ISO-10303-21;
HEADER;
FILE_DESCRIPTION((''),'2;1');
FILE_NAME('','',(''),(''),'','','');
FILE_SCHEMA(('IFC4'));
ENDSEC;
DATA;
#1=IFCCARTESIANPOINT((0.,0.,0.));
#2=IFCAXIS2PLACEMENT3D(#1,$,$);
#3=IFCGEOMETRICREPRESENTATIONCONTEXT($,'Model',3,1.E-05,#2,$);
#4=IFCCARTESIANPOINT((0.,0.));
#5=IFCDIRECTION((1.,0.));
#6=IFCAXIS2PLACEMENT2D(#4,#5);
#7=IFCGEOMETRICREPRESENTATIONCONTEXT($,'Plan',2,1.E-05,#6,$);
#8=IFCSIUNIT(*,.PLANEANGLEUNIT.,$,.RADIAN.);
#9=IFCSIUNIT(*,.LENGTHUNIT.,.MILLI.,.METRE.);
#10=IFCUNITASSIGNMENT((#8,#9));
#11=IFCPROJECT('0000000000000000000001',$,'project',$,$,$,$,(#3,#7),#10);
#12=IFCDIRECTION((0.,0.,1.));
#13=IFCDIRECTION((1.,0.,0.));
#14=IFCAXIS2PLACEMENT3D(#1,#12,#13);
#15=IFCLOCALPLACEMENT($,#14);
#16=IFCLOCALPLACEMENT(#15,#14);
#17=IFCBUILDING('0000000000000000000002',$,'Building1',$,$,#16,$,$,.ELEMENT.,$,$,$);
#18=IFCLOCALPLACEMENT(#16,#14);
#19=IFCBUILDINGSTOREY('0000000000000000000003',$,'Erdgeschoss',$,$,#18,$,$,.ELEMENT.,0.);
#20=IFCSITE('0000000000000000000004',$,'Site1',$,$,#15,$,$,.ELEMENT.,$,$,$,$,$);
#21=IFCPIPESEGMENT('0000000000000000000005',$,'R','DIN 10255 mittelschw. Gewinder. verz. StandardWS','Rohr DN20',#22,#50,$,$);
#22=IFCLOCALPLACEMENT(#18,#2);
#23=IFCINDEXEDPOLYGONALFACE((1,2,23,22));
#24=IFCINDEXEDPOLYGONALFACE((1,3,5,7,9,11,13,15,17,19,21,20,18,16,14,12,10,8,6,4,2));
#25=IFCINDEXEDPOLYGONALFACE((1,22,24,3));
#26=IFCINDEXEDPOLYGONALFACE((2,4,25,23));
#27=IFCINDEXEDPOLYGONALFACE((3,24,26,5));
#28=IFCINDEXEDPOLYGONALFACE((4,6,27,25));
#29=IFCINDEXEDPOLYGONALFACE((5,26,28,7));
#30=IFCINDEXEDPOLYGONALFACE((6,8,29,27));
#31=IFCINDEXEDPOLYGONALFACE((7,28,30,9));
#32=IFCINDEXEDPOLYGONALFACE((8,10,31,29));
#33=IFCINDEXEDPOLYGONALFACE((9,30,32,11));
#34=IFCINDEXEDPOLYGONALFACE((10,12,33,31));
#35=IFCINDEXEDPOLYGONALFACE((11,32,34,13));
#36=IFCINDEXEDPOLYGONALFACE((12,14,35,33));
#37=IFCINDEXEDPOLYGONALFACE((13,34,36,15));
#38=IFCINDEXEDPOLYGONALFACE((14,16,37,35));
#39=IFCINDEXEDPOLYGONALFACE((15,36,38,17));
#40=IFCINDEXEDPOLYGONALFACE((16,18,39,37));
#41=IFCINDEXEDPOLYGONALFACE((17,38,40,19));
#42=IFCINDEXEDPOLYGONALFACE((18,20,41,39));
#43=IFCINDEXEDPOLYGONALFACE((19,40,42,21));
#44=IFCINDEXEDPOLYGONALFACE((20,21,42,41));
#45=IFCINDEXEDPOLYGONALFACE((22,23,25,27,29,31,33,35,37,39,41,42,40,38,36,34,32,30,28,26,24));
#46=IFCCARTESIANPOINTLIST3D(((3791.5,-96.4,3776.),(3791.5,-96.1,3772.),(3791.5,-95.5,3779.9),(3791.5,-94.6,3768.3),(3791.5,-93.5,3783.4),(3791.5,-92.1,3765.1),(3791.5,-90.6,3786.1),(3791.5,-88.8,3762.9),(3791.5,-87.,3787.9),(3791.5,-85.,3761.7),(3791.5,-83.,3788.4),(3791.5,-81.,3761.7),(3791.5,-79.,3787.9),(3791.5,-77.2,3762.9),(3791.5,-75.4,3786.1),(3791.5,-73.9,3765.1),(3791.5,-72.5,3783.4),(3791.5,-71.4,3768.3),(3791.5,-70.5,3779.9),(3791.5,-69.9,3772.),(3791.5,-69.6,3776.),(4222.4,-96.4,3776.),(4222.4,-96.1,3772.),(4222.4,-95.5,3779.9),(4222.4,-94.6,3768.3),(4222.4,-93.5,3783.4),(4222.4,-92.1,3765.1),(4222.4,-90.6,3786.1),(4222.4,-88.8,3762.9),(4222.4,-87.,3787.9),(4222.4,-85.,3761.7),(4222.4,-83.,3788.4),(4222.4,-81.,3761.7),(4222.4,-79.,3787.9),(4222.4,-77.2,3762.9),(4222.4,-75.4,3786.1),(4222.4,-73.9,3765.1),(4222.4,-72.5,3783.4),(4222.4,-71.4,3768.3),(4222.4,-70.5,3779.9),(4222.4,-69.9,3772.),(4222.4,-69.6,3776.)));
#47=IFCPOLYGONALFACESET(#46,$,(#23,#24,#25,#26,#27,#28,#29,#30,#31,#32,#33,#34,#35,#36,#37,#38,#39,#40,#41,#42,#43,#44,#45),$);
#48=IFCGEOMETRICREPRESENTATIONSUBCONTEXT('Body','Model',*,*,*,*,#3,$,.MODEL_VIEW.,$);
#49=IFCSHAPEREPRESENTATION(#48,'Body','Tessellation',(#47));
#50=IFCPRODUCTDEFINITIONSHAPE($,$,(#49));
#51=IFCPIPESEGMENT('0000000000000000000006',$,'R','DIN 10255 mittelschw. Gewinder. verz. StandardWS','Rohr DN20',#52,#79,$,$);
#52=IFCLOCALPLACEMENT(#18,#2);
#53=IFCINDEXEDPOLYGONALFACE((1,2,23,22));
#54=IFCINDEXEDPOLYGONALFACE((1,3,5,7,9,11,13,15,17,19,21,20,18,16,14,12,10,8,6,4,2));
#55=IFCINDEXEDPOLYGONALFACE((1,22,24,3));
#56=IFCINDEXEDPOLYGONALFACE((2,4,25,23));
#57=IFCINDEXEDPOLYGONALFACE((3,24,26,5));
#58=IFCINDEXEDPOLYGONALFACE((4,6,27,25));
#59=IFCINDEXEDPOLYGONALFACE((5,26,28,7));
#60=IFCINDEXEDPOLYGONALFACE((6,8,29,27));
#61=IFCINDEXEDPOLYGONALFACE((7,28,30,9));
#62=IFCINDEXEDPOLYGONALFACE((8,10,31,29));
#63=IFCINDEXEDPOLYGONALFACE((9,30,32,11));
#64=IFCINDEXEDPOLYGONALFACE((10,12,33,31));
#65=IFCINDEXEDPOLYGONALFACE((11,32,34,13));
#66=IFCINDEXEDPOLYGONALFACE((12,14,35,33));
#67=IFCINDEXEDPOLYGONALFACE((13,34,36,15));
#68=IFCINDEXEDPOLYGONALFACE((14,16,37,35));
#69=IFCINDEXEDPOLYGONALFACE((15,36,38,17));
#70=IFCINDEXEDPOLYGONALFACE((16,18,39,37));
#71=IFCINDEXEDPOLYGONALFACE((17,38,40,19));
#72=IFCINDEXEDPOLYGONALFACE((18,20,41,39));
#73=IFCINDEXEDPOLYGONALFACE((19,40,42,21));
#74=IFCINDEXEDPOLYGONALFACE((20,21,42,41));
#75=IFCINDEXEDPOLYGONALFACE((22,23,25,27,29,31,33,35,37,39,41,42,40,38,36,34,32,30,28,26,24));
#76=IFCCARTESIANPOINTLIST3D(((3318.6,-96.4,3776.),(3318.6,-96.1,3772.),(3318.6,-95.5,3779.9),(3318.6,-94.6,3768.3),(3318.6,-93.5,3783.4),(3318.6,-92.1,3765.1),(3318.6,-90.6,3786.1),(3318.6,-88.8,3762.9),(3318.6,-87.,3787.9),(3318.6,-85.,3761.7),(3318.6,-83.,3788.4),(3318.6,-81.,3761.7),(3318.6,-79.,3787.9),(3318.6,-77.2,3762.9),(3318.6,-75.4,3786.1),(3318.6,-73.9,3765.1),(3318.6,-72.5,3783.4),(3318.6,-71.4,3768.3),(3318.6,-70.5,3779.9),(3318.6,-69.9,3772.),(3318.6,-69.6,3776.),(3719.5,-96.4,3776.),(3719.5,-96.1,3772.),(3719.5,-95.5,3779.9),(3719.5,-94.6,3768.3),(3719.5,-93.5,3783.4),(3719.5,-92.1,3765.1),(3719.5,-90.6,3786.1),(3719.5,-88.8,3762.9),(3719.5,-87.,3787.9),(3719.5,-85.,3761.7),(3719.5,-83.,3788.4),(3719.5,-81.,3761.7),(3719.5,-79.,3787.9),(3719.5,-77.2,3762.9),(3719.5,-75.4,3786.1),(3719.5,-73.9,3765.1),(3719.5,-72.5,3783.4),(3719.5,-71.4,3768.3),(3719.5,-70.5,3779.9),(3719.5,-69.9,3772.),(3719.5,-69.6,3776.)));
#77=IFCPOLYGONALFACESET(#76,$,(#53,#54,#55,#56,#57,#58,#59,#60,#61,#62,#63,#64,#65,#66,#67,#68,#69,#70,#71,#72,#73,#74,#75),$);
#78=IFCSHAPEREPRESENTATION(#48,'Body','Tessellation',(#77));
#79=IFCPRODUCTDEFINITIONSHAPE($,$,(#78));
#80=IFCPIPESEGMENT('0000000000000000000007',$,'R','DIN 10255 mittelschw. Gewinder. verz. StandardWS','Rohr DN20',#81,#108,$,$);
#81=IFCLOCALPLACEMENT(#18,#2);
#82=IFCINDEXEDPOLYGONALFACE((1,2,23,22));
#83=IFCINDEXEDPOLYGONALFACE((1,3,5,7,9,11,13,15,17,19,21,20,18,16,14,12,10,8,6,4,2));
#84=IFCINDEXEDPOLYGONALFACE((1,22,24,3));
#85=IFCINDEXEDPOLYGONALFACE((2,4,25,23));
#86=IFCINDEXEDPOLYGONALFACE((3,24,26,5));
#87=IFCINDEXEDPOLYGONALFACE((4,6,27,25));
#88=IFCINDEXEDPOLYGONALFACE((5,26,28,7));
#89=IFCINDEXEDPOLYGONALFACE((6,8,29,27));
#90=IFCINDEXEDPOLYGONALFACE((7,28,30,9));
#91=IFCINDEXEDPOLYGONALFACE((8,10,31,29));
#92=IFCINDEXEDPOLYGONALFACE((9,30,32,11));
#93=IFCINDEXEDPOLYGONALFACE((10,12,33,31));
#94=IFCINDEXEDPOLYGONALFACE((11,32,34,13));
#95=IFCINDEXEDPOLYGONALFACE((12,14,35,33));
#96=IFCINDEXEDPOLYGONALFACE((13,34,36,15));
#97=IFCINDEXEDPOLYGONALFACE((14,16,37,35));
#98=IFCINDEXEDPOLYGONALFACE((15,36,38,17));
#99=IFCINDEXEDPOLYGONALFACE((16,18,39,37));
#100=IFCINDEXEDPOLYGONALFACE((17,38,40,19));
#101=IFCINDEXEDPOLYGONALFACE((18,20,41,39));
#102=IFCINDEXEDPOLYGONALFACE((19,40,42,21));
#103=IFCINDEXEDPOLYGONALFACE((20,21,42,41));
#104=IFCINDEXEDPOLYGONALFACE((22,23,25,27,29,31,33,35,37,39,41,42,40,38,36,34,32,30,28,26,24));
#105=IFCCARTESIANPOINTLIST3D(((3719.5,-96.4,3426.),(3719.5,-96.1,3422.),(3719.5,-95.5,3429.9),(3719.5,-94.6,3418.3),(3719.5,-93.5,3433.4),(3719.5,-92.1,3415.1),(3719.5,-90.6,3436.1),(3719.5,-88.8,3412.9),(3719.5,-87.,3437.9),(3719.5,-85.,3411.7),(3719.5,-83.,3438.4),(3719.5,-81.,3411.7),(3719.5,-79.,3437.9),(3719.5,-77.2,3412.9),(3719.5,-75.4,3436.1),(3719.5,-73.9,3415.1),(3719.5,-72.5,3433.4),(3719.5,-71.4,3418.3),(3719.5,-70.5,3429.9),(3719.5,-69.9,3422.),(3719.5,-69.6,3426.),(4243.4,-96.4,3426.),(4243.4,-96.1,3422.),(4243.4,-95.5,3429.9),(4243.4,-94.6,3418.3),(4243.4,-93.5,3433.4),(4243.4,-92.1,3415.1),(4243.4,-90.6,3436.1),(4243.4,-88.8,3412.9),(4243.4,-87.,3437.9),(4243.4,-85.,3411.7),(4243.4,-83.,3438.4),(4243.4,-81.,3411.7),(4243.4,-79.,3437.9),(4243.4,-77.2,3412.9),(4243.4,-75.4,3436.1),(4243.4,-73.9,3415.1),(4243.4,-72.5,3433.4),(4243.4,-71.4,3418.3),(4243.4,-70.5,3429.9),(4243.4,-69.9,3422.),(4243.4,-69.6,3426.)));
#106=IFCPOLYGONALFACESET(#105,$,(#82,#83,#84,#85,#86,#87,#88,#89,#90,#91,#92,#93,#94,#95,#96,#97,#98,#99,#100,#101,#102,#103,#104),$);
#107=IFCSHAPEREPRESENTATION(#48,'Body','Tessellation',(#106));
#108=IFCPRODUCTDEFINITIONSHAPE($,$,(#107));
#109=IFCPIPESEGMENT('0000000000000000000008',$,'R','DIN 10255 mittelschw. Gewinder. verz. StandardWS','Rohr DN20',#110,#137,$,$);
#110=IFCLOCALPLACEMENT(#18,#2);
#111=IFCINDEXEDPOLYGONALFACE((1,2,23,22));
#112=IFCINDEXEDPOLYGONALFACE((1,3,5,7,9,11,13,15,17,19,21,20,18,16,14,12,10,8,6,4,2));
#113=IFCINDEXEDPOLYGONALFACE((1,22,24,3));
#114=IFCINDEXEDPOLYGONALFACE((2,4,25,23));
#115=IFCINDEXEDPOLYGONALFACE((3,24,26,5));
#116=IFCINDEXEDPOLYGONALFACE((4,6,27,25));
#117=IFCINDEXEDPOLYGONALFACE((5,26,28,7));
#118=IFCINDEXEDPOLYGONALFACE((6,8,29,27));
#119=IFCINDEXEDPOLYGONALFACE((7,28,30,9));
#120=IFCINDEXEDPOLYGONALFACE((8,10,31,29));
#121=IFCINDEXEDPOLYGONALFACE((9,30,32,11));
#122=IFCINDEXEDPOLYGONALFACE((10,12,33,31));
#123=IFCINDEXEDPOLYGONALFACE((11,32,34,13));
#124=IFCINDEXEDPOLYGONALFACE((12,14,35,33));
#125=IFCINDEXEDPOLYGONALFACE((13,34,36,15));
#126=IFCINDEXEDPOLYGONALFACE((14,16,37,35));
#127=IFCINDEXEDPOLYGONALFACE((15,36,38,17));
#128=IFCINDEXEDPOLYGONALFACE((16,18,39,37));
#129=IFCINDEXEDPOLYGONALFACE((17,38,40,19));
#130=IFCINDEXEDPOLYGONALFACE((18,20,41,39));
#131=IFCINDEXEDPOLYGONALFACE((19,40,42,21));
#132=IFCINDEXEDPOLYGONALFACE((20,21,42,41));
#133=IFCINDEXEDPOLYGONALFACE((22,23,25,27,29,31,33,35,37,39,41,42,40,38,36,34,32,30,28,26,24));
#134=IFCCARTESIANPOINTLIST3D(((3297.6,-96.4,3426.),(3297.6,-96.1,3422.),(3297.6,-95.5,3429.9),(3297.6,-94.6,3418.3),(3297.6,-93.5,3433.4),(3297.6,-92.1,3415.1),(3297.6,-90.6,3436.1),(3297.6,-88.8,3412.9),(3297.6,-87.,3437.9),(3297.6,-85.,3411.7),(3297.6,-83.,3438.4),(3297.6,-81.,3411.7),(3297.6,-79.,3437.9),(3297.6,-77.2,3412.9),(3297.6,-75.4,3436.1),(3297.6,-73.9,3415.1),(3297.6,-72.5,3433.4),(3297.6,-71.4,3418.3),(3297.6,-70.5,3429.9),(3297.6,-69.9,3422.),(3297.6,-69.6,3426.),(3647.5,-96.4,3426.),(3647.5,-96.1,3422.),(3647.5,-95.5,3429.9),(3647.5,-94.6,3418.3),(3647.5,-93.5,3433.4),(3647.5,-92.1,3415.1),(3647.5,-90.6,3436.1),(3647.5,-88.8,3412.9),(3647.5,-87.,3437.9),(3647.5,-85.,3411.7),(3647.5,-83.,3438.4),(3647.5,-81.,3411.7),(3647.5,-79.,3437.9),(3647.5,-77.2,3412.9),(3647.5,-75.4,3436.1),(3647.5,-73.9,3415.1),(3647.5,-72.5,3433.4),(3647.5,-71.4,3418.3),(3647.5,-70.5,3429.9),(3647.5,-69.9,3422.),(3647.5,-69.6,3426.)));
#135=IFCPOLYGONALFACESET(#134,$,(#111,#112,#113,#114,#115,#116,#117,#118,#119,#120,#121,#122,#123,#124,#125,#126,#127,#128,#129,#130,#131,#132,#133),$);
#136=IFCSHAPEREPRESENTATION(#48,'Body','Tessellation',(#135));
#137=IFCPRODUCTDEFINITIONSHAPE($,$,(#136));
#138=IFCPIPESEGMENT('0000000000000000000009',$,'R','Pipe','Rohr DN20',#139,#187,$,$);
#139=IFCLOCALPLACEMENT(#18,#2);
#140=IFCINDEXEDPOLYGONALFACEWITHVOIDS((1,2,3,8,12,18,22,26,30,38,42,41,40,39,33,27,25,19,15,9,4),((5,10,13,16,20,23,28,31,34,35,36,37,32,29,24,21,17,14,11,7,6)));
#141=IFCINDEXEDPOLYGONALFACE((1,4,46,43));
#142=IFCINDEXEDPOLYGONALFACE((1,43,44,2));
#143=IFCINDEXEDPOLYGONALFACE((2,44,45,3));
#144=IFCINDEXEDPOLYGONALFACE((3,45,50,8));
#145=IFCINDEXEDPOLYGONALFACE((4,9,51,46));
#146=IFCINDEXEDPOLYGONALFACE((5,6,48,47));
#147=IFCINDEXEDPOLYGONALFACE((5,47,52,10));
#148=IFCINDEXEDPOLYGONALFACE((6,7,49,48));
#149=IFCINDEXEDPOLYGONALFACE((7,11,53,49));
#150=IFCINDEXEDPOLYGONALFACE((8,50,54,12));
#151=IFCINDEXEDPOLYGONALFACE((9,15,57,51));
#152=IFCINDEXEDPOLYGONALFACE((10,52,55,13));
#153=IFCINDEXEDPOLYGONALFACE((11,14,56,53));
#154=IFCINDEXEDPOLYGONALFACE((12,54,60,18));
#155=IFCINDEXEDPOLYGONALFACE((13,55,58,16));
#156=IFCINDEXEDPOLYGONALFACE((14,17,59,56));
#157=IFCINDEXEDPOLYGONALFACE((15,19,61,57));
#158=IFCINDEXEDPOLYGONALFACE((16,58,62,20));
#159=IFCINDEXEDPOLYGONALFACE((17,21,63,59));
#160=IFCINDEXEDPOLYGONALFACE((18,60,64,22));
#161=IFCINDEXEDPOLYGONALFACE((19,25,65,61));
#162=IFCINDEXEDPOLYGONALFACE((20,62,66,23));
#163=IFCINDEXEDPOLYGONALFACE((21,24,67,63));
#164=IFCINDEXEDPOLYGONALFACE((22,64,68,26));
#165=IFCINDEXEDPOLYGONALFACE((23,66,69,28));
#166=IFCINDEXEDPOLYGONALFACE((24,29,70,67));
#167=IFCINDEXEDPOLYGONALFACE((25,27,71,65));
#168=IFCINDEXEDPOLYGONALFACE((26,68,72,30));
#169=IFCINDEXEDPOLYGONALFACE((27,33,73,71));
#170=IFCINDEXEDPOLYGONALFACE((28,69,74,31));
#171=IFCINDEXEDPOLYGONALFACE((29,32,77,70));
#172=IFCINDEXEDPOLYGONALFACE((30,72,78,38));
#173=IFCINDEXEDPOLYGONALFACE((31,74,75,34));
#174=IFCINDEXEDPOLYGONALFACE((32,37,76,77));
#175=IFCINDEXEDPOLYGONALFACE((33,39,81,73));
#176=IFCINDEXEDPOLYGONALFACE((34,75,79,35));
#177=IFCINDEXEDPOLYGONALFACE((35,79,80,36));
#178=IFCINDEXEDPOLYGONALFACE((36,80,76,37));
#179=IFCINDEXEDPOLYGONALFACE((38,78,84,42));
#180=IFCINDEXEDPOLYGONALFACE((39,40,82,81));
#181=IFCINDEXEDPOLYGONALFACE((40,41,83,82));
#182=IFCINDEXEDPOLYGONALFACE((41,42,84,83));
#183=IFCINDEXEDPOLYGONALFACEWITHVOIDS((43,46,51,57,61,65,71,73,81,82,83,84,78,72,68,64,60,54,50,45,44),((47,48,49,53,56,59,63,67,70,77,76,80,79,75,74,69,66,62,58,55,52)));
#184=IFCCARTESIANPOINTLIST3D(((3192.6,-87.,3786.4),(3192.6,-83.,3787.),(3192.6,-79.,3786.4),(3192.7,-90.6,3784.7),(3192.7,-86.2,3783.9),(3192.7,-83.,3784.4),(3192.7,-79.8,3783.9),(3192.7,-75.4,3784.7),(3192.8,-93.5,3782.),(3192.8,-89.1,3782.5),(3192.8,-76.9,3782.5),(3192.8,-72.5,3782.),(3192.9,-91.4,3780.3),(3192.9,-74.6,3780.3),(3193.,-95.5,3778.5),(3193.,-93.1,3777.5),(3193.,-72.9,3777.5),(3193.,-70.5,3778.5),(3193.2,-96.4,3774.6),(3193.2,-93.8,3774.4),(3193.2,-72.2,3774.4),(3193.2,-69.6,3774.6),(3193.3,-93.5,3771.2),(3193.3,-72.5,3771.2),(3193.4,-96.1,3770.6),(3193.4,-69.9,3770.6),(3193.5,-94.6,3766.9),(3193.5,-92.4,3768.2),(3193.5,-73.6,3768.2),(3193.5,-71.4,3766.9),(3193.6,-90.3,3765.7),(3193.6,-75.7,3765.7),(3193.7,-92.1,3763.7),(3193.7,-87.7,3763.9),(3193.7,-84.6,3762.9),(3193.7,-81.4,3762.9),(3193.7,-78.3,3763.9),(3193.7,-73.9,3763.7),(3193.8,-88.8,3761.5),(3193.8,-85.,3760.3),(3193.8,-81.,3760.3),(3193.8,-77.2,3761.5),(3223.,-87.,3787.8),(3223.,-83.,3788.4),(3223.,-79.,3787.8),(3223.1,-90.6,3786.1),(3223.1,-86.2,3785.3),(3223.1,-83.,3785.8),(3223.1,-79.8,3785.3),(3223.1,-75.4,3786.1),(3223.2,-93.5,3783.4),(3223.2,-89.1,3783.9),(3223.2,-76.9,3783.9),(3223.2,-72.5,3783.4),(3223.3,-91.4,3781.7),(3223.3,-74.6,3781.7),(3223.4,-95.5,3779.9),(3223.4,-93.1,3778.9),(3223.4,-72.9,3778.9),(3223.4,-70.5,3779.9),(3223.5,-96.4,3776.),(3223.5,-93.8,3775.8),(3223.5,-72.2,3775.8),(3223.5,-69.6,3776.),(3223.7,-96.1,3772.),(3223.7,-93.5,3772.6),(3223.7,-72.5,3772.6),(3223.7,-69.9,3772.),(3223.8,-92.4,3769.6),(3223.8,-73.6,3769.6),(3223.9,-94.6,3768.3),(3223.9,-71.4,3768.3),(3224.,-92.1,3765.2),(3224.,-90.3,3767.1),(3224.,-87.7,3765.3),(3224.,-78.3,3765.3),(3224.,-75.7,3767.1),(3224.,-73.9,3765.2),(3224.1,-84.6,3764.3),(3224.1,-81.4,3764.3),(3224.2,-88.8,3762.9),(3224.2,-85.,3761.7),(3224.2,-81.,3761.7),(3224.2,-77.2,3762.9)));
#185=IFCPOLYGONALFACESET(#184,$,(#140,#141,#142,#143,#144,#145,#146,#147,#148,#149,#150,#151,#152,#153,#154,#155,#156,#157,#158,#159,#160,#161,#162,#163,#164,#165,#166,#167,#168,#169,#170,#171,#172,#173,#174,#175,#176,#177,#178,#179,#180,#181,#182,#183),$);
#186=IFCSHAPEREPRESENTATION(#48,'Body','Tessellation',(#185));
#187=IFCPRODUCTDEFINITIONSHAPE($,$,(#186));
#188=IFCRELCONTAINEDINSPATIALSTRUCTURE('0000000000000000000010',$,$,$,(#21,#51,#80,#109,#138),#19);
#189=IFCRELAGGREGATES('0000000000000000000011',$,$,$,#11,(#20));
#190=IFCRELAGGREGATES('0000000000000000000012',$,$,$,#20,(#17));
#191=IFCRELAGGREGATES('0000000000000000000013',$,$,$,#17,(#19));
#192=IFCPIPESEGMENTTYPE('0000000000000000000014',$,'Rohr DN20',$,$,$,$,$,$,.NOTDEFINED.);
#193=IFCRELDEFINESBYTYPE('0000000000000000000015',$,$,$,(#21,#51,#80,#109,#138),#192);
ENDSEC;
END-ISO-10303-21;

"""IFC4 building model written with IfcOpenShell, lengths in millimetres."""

from ifc_helpers import new_model, si_unit, frame, origin, origin_with_axes, origin_2d_with_axis, place, context, subcontext, project, spatial, circle, hollow_circle, extrude, type_object, element, save


model = new_model("IFC4")

# Units and contexts
model_context = context("Model", 3, precision=1e-05, world=origin())
plan_context = context("Plan", 2, precision=1e-05, world=origin_2d_with_axis())
body_context = subcontext(model_context, "Body", "Model", "MODEL_VIEW")
ifc_project = project(units=[si_unit("PLANEANGLEUNIT", "RADIAN"), si_unit("LENGTHUNIT", "METRE", prefix="MILLI")], contexts=[model_context, plan_context])

# Site, building, storey
site_placement = place(None, origin_with_axes())
site = spatial("IfcSite", under=ifc_project, at=site_placement, Name="Site1", CompositionType="ELEMENT")
building_placement = place(site_placement, origin_with_axes())
building = spatial("IfcBuilding", under=site, at=building_placement, Name="Building1", CompositionType="ELEMENT")
storey_placement = place(building_placement, origin_with_axes())
storey = spatial("IfcBuildingStorey", under=building, at=storey_placement, Name="Erdgeschoss", CompositionType="ELEMENT", Elevation=0.0)

# Pipe segments
pipe_segment_type_1 = type_object("IfcPipeSegmentType", Name="Rohr DN20", PredefinedType="NOTDEFINED")
pipe_segment_1_placement = place(storey_placement, frame((4006.9, -83.2, 3775.0), z_axis=(0.0, 0.0, 1.0), x_axis=(1.0, 0.0, 0.0)))
element("IfcPipeSegment", 1, at=pipe_segment_1_placement, inside=storey, type_object=pipe_segment_type_1, Name="R", Description="DIN 10255 mittelschw. Gewinder. verz. StandardWS", ObjectType="Rohr DN20", context=body_context, shape_type="SolidModel", body=[
    extrude(circle(Radius=13.4, at=origin_2d_with_axis()), frame((215.5, 0.2, 0.0), z_axis=(-1.0, 0.0, 0.0), x_axis=(0.0, 0.0, 1.0)), (0.0, 0.0, 1.0), 430.9),
])
pipe_segment_2_placement = place(storey_placement, frame((3519.0, -83.2, 3775.0), z_axis=(0.0, 0.0, 1.0), x_axis=(1.0, 0.0, 0.0)))
element("IfcPipeSegment", 2, at=pipe_segment_2_placement, inside=storey, type_object=pipe_segment_type_1, Name="R", Description="DIN 10255 mittelschw. Gewinder. verz. StandardWS", ObjectType="Rohr DN20", context=body_context, shape_type="SolidModel", body=[
    extrude(circle(Radius=13.4, at=origin_2d_with_axis()), frame((200.5, 0.2, 0.0), z_axis=(-1.0, 0.0, 0.0), x_axis=(0.0, 0.0, 1.0)), (0.0, 0.0, 1.0), 400.9),
])
pipe_segment_3_placement = place(storey_placement, frame((3981.4, -83.2, 3425.0), z_axis=(0.0, 0.0, 1.0), x_axis=(1.0, 0.0, 0.0)))
element("IfcPipeSegment", 3, at=pipe_segment_3_placement, inside=storey, type_object=pipe_segment_type_1, Name="R", Description="DIN 10255 mittelschw. Gewinder. verz. StandardWS", ObjectType="Rohr DN20", context=body_context, shape_type="SolidModel", body=[
    extrude(circle(Radius=13.4, at=origin_2d_with_axis()), frame((261.9, 0.2, 0.0), z_axis=(-1.0, 0.0, 0.0), x_axis=(0.0, 0.0, 1.0)), (0.0, 0.0, 1.0), 523.9),
])
pipe_segment_4_placement = place(storey_placement, frame((3472.5, -83.2, 3425.0), z_axis=(0.0, 0.0, 1.0), x_axis=(1.0, 0.0, 0.0)))
element("IfcPipeSegment", 4, at=pipe_segment_4_placement, inside=storey, type_object=pipe_segment_type_1, Name="R", Description="DIN 10255 mittelschw. Gewinder. verz. StandardWS", ObjectType="Rohr DN20", context=body_context, shape_type="SolidModel", body=[
    extrude(circle(Radius=13.4, at=origin_2d_with_axis()), frame((175.0, 0.2, 0.0), z_axis=(-1.0, 0.0, 0.0), x_axis=(0.0, 0.0, 1.0)), (0.0, 0.0, 1.0), 349.9),
])
pipe_segment_5_placement = place(storey_placement, frame((3208.4, -82.8, 3774.3), z_axis=(0.0, 0.0, 1.0), x_axis=(1.0, 0.0, 0.0)))
element("IfcPipeSegment", 5, at=pipe_segment_5_placement, inside=storey, type_object=pipe_segment_type_1, Name="R", Description="Pipe", ObjectType="Rohr DN20", context=body_context, shape_type="SolidModel", body=[
    extrude(hollow_circle(Radius=13.4, WallThickness=2.6, at=origin_2d_with_axis()), frame((-15.2, -0.1, -0.7), z_axis=(0.998901, 0.0, 0.046868), x_axis=(0.0, 0.0, 1.0)), (0.0, 0.0, 1.0), 30.4),
])

save(model, "model.ifc")
